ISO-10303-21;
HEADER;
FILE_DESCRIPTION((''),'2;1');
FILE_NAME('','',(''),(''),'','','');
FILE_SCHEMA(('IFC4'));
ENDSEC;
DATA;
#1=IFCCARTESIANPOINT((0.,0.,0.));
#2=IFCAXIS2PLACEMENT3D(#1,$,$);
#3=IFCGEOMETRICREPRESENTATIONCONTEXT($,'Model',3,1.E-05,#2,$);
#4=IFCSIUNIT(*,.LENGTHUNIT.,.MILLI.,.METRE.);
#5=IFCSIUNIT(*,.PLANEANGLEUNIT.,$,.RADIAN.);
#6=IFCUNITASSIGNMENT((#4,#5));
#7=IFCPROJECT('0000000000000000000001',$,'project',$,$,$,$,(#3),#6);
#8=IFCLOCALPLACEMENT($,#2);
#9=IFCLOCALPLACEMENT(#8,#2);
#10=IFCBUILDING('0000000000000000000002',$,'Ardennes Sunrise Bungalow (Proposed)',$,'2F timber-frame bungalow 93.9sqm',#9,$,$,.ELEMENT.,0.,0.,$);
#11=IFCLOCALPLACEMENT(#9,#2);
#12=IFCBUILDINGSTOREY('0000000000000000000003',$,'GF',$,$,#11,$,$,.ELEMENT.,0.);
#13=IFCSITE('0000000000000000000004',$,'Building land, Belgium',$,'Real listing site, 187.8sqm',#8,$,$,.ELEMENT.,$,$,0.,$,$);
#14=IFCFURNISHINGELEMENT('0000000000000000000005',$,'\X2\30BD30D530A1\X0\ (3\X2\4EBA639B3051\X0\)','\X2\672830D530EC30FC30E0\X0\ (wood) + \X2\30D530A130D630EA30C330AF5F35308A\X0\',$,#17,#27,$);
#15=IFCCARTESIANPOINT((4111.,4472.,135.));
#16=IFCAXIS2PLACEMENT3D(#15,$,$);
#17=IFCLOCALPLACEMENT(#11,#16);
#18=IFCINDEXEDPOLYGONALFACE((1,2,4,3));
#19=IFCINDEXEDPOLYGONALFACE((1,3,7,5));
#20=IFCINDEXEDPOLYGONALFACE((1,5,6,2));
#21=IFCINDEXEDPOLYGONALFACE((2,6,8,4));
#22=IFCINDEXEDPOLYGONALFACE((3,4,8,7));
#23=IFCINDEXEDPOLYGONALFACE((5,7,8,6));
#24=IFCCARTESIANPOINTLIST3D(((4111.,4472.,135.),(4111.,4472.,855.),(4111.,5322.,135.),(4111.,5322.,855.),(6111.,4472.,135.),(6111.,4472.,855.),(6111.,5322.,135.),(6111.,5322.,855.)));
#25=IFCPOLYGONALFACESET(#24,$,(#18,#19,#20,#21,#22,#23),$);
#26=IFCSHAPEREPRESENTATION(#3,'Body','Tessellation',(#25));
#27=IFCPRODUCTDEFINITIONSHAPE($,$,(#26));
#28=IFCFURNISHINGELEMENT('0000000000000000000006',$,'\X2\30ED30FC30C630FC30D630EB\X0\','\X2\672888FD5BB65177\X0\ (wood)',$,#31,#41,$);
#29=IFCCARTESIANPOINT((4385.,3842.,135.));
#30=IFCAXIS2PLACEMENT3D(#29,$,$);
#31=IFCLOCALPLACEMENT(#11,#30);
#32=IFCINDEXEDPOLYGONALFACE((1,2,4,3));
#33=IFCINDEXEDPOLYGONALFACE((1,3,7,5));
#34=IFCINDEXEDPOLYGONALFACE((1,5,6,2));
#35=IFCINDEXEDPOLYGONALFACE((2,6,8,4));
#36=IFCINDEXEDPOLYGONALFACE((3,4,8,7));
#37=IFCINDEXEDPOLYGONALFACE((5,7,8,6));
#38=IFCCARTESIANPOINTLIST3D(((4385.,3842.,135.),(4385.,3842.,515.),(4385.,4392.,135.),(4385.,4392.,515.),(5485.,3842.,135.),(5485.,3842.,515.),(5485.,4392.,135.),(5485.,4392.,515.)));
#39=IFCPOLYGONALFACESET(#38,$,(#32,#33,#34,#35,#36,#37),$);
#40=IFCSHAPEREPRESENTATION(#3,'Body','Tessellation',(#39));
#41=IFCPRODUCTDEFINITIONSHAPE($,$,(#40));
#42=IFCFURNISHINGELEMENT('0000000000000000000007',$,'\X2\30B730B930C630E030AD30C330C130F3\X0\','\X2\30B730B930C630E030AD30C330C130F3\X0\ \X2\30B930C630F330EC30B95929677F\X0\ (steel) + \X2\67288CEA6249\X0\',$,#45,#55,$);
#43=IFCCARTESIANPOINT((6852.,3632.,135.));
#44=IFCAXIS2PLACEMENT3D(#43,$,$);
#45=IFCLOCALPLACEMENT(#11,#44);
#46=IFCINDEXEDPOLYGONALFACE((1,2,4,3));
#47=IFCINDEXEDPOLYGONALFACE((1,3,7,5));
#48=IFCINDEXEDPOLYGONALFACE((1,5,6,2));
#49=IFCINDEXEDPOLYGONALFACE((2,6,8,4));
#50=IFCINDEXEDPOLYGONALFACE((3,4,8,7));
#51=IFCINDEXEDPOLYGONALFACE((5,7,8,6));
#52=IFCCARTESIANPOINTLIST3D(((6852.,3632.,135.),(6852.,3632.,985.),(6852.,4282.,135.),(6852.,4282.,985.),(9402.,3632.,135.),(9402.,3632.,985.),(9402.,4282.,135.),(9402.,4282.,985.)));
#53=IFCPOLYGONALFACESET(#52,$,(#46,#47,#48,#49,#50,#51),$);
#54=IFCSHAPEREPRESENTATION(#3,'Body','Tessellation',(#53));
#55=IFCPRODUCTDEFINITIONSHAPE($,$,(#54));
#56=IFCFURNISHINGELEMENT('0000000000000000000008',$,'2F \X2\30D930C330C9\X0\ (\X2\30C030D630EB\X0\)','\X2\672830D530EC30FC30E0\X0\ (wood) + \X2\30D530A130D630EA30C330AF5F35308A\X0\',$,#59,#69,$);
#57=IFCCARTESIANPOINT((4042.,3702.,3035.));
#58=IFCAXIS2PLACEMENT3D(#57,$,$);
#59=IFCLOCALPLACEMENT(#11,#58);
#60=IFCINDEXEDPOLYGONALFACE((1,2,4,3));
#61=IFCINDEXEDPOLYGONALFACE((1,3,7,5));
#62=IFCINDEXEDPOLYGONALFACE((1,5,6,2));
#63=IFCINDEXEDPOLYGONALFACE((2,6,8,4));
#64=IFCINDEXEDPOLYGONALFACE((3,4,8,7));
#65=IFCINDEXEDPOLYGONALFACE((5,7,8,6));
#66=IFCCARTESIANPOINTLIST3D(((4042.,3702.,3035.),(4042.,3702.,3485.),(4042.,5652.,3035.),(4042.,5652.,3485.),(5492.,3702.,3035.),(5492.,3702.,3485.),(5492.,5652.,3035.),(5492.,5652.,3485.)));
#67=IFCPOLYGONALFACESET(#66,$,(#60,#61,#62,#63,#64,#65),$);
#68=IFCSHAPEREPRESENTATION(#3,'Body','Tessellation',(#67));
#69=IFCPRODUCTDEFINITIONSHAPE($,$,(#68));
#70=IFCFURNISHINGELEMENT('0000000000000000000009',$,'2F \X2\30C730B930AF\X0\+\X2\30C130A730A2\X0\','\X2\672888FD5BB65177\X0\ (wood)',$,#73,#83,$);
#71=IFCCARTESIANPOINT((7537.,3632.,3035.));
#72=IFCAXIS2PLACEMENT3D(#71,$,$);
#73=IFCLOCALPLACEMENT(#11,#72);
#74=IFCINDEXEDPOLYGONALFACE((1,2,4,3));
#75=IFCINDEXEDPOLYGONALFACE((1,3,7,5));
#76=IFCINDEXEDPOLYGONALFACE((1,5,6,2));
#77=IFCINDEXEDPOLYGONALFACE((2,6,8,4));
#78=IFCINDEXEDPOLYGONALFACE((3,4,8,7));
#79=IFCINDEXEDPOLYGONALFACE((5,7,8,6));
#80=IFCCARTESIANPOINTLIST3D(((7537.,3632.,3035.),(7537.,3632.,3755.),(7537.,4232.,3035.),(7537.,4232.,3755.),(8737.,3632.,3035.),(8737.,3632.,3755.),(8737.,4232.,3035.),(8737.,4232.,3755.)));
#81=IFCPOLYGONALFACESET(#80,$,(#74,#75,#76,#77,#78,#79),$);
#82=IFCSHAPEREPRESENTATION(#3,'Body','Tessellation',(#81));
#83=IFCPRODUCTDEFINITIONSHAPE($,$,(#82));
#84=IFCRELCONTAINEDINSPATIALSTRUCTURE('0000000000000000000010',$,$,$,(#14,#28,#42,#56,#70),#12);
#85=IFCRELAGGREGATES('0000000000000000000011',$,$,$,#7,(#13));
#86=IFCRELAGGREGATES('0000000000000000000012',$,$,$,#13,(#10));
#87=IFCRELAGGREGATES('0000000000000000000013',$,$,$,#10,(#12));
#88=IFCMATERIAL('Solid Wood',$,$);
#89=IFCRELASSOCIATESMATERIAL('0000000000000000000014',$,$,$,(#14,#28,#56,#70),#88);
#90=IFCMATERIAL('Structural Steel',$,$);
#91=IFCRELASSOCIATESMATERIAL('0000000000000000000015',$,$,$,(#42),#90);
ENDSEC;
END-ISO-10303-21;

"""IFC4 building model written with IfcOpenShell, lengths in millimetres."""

from ifc_helpers import new_model, si_unit, frame, frame_2d, origin, place, context, project, spatial, rectangle, extrude, material, element, save


model = new_model("IFC4")

# Units and contexts
model_context = context("Model", 3, precision=1e-05, world=origin())
ifc_project = project(units=[si_unit("LENGTHUNIT", "METRE", prefix="MILLI"), si_unit("PLANEANGLEUNIT", "RADIAN")], contexts=[model_context])

# Site, building, storey
site_placement = place(None, origin())
site = spatial("IfcSite", under=ifc_project, at=site_placement, Name="Building land, Belgium", ObjectType="Real listing site, 187.8sqm", CompositionType="ELEMENT", RefElevation=0.0)
building_placement = place(site_placement, origin())
building = spatial("IfcBuilding", under=site, at=building_placement, Name="Ardennes Sunrise Bungalow (Proposed)", ObjectType="2F timber-frame bungalow 93.9sqm", CompositionType="ELEMENT", ElevationOfRefHeight=0.0, ElevationOfTerrain=0.0)
storey_placement = place(building_placement, origin())
storey = spatial("IfcBuildingStorey", under=building, at=storey_placement, Name="GF", CompositionType="ELEMENT", Elevation=0.0)

# Shared definitions
ifc_material_1 = material(Name="Solid Wood")

# Shared definitions
ifc_material_2 = material(Name="Structural Steel")

# Furnishing elements
furnishing_1_placement = place(storey_placement, frame((4111.0, 4472.0, 135.0)))
element("IfcFurnishingElement", 1, at=furnishing_1_placement, inside=storey, material=ifc_material_1, Name="ソファ (3人掛け)", Description="木フレーム (wood) + ファブリック張り", context=model_context, shape_type="SweptSolid", body=[
    extrude(rectangle(XDim=2000.0, YDim=850.0, at=frame_2d((1000.0, 425.0))), frame((4111.0, 4472.0, 135.0)), (0.0, 0.0, 1.0), 720.0),
])
furnishing_2_placement = place(storey_placement, frame((4385.0, 3842.0, 135.0)))
element("IfcFurnishingElement", 2, at=furnishing_2_placement, inside=storey, material=ifc_material_1, Name="ローテーブル", Description="木製家具 (wood)", context=model_context, shape_type="SweptSolid", body=[
    extrude(rectangle(XDim=1100.0, YDim=550.0, at=frame_2d((550.0, 275.0))), frame((4385.0, 3842.0, 135.0)), (0.0, 0.0, 1.0), 380.0),
])
furnishing_3_placement = place(storey_placement, frame((6852.0, 3632.0, 135.0)))
element("IfcFurnishingElement", 3, at=furnishing_3_placement, inside=storey, material=ifc_material_2, Name="システムキッチン", Description="システムキッチン ステンレス天板 (steel) + 木質扉", context=model_context, shape_type="SweptSolid", body=[
    extrude(rectangle(XDim=2550.0, YDim=650.0, at=frame_2d((1275.0, 325.0))), frame((6852.0, 3632.0, 135.0)), (0.0, 0.0, 1.0), 850.0),
])
furnishing_4_placement = place(storey_placement, frame((4042.0, 3702.0, 3035.0)))
element("IfcFurnishingElement", 4, at=furnishing_4_placement, inside=storey, material=ifc_material_1, Name="2F ベッド (ダブル)", Description="木フレーム (wood) + ファブリック張り", context=model_context, shape_type="SweptSolid", body=[
    extrude(rectangle(XDim=1450.0, YDim=1950.0, at=frame_2d((725.0, 975.0))), frame((4042.0, 3702.0, 3035.0)), (0.0, 0.0, 1.0), 450.0),
])
furnishing_5_placement = place(storey_placement, frame((7537.0, 3632.0, 3035.0)))
element("IfcFurnishingElement", 5, at=furnishing_5_placement, inside=storey, material=ifc_material_1, Name="2F デスク+チェア", Description="木製家具 (wood)", context=model_context, shape_type="SweptSolid", body=[
    extrude(rectangle(XDim=1200.0, YDim=600.0, at=frame_2d((600.0, 300.0))), frame((7537.0, 3632.0, 3035.0)), (0.0, 0.0, 1.0), 720.0),
])

save(model, "model.ifc")
